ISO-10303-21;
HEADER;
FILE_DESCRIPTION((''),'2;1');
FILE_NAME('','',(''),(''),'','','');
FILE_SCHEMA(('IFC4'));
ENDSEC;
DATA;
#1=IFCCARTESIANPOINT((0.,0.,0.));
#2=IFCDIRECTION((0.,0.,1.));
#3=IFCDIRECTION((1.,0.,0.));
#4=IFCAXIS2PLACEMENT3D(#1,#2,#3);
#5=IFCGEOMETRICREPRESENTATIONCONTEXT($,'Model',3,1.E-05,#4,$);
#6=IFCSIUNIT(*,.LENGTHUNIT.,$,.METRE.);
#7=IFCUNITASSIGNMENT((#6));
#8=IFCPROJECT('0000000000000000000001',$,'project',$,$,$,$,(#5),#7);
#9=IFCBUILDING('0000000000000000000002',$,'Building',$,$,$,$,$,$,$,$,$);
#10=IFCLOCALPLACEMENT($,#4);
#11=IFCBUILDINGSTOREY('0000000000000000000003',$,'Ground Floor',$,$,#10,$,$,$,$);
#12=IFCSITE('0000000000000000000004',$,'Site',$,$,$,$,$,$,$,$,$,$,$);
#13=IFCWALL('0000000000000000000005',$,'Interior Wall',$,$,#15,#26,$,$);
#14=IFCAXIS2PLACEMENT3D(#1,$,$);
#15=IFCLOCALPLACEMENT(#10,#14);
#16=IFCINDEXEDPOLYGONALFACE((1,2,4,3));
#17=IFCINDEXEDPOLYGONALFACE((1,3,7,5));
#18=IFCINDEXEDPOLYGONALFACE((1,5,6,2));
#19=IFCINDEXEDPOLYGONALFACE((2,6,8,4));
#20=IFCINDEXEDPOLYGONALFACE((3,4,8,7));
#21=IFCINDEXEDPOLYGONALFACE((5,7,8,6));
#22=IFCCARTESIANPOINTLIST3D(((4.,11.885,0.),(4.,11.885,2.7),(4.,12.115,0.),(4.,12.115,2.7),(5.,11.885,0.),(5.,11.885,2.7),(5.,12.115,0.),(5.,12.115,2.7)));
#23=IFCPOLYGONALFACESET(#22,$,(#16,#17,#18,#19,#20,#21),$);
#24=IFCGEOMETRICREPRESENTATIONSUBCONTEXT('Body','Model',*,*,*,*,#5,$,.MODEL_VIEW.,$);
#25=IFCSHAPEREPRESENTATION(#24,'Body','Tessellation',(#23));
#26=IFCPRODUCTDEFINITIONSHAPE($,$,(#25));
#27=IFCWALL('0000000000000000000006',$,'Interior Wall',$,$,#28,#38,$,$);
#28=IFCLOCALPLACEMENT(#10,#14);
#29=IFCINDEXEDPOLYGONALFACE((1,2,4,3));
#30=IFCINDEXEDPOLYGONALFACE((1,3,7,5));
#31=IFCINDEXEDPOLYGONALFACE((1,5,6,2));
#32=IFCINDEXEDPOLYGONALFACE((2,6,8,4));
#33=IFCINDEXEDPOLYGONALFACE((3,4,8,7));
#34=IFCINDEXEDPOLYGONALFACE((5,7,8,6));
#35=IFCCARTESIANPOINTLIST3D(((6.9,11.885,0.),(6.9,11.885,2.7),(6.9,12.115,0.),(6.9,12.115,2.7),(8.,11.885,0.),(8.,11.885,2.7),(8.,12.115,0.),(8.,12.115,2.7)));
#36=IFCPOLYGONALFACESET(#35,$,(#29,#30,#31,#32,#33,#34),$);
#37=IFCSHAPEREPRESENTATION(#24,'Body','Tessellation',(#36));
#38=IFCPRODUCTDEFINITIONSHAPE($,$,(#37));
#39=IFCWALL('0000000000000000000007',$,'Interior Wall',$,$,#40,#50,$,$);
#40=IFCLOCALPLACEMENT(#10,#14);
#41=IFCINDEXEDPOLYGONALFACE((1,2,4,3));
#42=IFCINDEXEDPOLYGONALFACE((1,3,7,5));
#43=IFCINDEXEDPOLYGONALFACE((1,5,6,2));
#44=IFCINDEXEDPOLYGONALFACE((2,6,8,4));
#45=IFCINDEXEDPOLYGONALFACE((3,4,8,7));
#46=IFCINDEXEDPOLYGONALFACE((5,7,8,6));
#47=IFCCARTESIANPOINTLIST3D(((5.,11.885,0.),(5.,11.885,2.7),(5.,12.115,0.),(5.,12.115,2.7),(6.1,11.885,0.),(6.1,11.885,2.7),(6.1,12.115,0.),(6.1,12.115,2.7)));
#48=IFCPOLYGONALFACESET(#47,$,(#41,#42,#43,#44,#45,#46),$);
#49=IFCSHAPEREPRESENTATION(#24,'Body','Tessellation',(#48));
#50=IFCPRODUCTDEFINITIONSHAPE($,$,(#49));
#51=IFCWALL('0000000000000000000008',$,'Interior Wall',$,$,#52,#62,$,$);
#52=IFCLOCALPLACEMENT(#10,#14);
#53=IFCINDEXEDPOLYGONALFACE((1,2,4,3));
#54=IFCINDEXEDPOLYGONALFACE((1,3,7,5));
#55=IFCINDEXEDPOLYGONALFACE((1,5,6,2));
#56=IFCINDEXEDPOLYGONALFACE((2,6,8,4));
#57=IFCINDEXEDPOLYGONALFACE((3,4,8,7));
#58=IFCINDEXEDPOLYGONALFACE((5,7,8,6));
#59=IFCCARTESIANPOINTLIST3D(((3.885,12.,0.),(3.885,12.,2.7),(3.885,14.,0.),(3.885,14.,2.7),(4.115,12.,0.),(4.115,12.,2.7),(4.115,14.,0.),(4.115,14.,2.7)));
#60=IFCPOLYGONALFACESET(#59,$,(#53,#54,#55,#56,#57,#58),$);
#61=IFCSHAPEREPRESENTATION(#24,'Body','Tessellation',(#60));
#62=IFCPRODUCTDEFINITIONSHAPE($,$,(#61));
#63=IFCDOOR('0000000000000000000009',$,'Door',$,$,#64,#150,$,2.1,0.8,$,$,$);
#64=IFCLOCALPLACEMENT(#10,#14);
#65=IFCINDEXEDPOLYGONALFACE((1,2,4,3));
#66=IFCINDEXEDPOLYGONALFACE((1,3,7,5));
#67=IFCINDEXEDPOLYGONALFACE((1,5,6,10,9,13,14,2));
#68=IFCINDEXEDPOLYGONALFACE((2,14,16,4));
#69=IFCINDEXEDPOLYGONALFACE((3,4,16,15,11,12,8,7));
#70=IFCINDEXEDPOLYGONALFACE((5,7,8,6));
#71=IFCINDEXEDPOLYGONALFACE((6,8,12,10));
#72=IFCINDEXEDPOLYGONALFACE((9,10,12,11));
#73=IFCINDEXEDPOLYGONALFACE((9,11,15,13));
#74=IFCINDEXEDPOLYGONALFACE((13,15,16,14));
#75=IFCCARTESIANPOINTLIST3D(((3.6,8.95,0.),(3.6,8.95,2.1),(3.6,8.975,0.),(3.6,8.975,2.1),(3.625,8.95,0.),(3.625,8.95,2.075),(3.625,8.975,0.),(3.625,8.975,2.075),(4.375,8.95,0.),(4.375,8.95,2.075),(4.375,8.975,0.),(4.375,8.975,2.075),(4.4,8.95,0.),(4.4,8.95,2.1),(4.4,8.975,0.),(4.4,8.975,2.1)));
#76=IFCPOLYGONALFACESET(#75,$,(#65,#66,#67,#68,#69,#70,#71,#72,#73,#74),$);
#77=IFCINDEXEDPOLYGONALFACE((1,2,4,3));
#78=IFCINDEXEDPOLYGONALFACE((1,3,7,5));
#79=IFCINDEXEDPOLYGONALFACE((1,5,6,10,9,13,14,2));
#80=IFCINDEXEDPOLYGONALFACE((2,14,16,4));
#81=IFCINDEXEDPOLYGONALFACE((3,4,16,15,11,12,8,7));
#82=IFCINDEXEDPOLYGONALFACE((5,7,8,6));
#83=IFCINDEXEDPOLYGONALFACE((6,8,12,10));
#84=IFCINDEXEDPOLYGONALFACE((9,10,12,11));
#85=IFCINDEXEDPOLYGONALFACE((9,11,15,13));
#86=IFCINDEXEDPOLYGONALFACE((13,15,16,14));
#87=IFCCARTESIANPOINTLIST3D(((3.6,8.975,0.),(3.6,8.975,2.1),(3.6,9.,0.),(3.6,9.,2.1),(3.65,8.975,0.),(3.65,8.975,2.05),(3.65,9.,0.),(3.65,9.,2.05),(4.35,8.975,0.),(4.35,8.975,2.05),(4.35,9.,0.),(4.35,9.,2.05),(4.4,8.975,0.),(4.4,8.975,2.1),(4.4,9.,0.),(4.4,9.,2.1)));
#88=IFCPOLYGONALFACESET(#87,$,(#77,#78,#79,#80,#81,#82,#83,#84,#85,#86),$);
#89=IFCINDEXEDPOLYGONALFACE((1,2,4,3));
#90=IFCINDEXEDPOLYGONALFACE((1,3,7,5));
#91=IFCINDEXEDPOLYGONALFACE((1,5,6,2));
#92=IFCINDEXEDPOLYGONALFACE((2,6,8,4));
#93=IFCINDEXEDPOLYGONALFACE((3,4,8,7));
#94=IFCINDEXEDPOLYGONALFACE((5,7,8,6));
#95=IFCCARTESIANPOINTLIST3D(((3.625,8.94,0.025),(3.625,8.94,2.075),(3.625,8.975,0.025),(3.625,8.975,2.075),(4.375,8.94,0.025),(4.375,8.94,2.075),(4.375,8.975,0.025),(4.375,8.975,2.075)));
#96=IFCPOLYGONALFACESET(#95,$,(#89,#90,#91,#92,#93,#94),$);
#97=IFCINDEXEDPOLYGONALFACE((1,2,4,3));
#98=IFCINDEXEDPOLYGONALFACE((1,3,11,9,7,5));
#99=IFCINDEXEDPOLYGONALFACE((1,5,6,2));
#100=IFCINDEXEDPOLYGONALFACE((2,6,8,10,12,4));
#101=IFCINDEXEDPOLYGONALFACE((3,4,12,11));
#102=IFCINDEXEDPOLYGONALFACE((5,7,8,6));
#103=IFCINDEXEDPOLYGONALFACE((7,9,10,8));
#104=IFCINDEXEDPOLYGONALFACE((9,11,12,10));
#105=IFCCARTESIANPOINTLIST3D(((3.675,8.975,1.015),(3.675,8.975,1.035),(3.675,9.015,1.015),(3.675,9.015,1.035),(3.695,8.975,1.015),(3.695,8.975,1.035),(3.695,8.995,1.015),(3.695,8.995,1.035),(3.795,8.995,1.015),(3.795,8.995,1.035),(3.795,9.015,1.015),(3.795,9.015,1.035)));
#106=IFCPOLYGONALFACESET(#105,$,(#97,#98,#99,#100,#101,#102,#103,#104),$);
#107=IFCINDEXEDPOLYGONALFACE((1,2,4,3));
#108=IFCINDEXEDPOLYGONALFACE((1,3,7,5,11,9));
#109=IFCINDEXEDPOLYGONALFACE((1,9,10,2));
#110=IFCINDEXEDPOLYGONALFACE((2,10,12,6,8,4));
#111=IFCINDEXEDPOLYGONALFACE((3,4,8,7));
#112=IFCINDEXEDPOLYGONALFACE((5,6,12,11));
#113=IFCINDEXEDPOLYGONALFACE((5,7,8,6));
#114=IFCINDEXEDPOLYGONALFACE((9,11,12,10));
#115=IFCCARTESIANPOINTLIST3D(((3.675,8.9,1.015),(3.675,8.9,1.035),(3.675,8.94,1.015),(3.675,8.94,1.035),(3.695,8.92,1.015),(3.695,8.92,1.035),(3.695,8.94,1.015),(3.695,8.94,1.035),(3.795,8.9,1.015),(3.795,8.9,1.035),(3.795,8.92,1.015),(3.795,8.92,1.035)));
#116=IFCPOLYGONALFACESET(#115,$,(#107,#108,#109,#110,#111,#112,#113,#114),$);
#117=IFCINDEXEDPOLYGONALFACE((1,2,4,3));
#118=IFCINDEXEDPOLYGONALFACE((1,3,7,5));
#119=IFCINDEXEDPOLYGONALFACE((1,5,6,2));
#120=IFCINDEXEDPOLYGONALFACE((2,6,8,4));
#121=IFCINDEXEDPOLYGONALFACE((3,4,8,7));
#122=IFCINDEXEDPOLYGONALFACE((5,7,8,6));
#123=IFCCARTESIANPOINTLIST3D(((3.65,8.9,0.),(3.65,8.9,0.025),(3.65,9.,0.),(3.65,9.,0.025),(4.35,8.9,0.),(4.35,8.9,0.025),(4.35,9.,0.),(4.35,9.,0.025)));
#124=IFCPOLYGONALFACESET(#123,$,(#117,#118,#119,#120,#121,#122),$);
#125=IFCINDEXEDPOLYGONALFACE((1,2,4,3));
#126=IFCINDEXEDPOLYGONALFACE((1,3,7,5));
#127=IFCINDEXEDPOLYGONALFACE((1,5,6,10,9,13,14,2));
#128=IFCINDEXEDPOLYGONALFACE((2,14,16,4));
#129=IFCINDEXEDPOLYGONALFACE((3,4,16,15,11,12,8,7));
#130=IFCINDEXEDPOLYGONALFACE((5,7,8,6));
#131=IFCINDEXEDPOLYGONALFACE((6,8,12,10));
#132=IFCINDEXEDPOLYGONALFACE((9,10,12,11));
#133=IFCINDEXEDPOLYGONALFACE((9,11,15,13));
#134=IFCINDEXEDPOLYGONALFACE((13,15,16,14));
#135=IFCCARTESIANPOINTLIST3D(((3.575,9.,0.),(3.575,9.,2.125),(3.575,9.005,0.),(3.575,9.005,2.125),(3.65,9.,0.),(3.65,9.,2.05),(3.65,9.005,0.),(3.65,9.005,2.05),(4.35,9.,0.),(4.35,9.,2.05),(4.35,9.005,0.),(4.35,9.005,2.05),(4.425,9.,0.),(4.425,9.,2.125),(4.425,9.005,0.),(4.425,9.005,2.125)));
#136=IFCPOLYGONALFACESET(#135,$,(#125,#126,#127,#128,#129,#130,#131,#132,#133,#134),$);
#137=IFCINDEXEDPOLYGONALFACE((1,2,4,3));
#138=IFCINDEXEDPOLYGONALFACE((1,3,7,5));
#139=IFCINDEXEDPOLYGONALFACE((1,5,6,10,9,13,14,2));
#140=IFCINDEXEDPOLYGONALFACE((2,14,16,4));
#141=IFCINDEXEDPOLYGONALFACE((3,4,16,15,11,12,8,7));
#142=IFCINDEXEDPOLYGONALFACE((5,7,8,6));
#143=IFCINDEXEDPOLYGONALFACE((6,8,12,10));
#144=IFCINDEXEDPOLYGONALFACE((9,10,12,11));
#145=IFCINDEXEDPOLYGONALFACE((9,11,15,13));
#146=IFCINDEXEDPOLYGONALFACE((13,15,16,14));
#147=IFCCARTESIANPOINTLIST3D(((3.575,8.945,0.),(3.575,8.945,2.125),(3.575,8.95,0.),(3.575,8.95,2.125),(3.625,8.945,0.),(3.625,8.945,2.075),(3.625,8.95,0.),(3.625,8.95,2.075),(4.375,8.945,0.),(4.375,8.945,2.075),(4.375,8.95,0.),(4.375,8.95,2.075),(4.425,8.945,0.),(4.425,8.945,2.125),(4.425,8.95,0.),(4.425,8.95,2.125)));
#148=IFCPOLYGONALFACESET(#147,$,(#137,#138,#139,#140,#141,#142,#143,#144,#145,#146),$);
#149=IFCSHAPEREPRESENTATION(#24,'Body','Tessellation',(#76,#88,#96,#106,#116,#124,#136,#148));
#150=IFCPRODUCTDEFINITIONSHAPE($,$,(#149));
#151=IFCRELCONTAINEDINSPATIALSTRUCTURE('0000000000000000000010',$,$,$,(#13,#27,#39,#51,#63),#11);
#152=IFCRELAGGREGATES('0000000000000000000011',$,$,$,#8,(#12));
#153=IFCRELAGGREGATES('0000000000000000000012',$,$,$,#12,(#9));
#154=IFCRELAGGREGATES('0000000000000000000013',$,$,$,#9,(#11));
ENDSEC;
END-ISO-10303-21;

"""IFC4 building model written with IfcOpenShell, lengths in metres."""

from ifc_helpers import new_model, si_unit, frame, origin_with_axes, place, context, subcontext, project, spatial, line, indexed_curve, outline, extrude, element, save


model = new_model("IFC4")

# Units and contexts
model_context = context("Model", 3, precision=1e-05, world=origin_with_axes())
body_context = subcontext(model_context, "Body", "Model", "MODEL_VIEW")
ifc_project = project(units=[si_unit("LENGTHUNIT", "METRE")], contexts=[model_context])

# Site, building, storey
site = spatial("IfcSite", under=ifc_project, Name="Site")
building = spatial("IfcBuilding", under=site, Name="Building")
storey_placement = place(None, origin_with_axes())
storey = spatial("IfcBuildingStorey", under=building, at=storey_placement, Name="Ground Floor")

# Walls
wall_1_placement = place(storey_placement, frame((5.0, 12.0, 0.0), z_axis=(0.0, 0.0, 1.0), x_axis=(-1.0, 0.0, 0.0)))
element("IfcWall", 1, at=wall_1_placement, inside=storey, Name="Interior Wall", context=body_context, shape_type="SweptSolid", body=[
    extrude(outline(indexed_curve([(0.0, 0.0), (0.0, 0.23), (1.0, 0.23), (1.0, 0.0), (0.0, 0.0)], self_intersect=False)), frame((0.0, -0.115, 0.0), z_axis=(0.0, 0.0, 1.0), x_axis=(1.0, 0.0, 0.0)), (0.0, 0.0, 1.0), 2.7),
])
for number, where, z_axis, x_axis, name in (
    (2, (8.0, 12.0, 0.0), (0.0, 0.0, 1.0), (-1.0, 0.0, 0.0), "Interior Wall"),
    (3, (6.1, 12.0, 0.0), (0.0, 0.0, 1.0), (-1.0, 0.0, 0.0), "Interior Wall"),
):
    element("IfcWall", number, at=place(storey_placement, frame(where, z_axis=z_axis, x_axis=x_axis)), inside=storey, Name=name, context=body_context, shape_type="SweptSolid", body=[
        extrude(outline(indexed_curve([(0.0, 0.0), (0.0, 0.23), (1.1, 0.23), (1.1, 0.0), (0.0, 0.0)], self_intersect=False)), frame((0.0, -0.115, 0.0), z_axis=(0.0, 0.0, 1.0), x_axis=(1.0, 0.0, 0.0)), (0.0, 0.0, 1.0), 2.7),
    ])
wall_2_placement = place(storey_placement, frame((4.0, 12.0, 0.0), z_axis=(0.0, 0.0, 1.0), x_axis=(0.0, 1.0, 0.0)))
element("IfcWall", 4, at=wall_2_placement, inside=storey, Name="Interior Wall", context=body_context, shape_type="SweptSolid", body=[
    extrude(outline(indexed_curve([(0.0, 0.0), (0.0, 0.23), (2.0, 0.23), (2.0, 0.0), (0.0, 0.0)], self_intersect=False)), frame((0.0, -0.115, 0.0), z_axis=(0.0, 0.0, 1.0), x_axis=(1.0, 0.0, 0.0)), (0.0, 0.0, 1.0), 2.7),
])

# Door
door_1_placement = place(storey_placement, frame((4.4, 9.0, 0.0), z_axis=(0.0, 0.0, 1.0), x_axis=(-1.0, 0.0, 0.0)))
element("IfcDoor", 5, at=door_1_placement, inside=storey, Name="Door", OverallHeight=2.1, OverallWidth=0.8, context=body_context, shape_type="SweptSolid", body=[
    extrude(outline(indexed_curve([(0.0, 0.0), (0.0, 2.1), (0.8, 2.1), (0.8, 0.0), (0.775, 0.0), (0.775, 2.075), (0.025, 2.075), (0.025, 0.0)], segments=[line(1, 2, 3, 4, 5, 6, 7, 8, 1)])), frame((0.0, 0.025, 0.0), z_axis=(0.0, -1.0, 0.0), x_axis=(1.0, 0.0, 0.0)), (0.0, 0.0, -1.0), 0.025),
    extrude(outline(indexed_curve([(0.0, 0.0), (0.0, 2.1), (0.8, 2.1), (0.8, 0.0), (0.75, 0.0), (0.75, 2.05), (0.05, 2.05), (0.05, 0.0)], segments=[line(1, 2, 3, 4, 5, 6, 7, 8, 1)])), frame((0.0, 0.0, 0.0), z_axis=(0.0, -1.0, 0.0), x_axis=(1.0, 0.0, 0.0)), (0.0, 0.0, -1.0), 0.025),
    extrude(outline(indexed_curve([(0.0, 0.0), (0.75, 0.0), (0.75, 0.035), (0.0, 0.035)], segments=[line(1, 2, 3, 4, 1)])), frame((0.025, 0.025, 0.025), z_axis=(0.0, 0.0, 1.0), x_axis=(1.0, 0.0, 0.0)), (0.0, 0.0, 1.0), 2.05),
    extrude(outline(indexed_curve([(0.0, 0.0), (0.0, -0.04), (-0.12, -0.04), (-0.12, -0.02), (-0.02, -0.02), (-0.02, 0.0)], segments=[line(1, 2, 3, 4, 5, 6, 1)])), frame((0.725, 0.025, 1.015), z_axis=(0.0, 0.0, 1.0), x_axis=(1.0, 0.0, 0.0)), (0.0, 0.0, 1.0), 0.02),
    extrude(outline(indexed_curve([(0.0, 0.0), (0.0, 0.04), (-0.12, 0.04), (-0.12, 0.02), (-0.02, 0.02), (-0.02, 0.0)], segments=[line(1, 2, 3, 4, 5, 6, 1)])), frame((0.725, 0.06, 1.015), z_axis=(0.0, 0.0, 1.0), x_axis=(1.0, 0.0, 0.0)), (0.0, 0.0, 1.0), 0.02),
    extrude(outline(indexed_curve([(0.0, 0.0), (0.7, 0.0), (0.7, 0.1), (0.0, 0.1)], segments=[line(1, 2, 3, 4, 1)])), frame((0.05, 0.0, 0.0), z_axis=(0.0, 0.0, 1.0), x_axis=(1.0, 0.0, 0.0)), (0.0, 0.0, 1.0), 0.025),
    extrude(outline(indexed_curve([(0.0, 0.0), (0.0, 2.125), (0.85, 2.125), (0.85, 0.0), (0.775, 0.0), (0.775, 2.05), (0.075, 2.05), (0.075, 0.0)], segments=[line(1, 2, 3, 4, 5, 6, 7, 8, 1)])), frame((-0.025, -0.005, 0.0), z_axis=(0.0, -1.0, 0.0), x_axis=(1.0, 0.0, 0.0)), (0.0, 0.0, -1.0), 0.005),
    extrude(outline(indexed_curve([(0.0, 0.0), (0.0, 2.125), (0.85, 2.125), (0.85, 0.0), (0.8, 0.0), (0.8, 2.075), (0.05, 2.075), (0.05, 0.0)], segments=[line(1, 2, 3, 4, 5, 6, 7, 8, 1)])), frame((-0.025, 0.05, 0.0), z_axis=(0.0, -1.0, 0.0), x_axis=(1.0, 0.0, 0.0)), (0.0, 0.0, -1.0), 0.005),
])

save(model, "model.ifc")
